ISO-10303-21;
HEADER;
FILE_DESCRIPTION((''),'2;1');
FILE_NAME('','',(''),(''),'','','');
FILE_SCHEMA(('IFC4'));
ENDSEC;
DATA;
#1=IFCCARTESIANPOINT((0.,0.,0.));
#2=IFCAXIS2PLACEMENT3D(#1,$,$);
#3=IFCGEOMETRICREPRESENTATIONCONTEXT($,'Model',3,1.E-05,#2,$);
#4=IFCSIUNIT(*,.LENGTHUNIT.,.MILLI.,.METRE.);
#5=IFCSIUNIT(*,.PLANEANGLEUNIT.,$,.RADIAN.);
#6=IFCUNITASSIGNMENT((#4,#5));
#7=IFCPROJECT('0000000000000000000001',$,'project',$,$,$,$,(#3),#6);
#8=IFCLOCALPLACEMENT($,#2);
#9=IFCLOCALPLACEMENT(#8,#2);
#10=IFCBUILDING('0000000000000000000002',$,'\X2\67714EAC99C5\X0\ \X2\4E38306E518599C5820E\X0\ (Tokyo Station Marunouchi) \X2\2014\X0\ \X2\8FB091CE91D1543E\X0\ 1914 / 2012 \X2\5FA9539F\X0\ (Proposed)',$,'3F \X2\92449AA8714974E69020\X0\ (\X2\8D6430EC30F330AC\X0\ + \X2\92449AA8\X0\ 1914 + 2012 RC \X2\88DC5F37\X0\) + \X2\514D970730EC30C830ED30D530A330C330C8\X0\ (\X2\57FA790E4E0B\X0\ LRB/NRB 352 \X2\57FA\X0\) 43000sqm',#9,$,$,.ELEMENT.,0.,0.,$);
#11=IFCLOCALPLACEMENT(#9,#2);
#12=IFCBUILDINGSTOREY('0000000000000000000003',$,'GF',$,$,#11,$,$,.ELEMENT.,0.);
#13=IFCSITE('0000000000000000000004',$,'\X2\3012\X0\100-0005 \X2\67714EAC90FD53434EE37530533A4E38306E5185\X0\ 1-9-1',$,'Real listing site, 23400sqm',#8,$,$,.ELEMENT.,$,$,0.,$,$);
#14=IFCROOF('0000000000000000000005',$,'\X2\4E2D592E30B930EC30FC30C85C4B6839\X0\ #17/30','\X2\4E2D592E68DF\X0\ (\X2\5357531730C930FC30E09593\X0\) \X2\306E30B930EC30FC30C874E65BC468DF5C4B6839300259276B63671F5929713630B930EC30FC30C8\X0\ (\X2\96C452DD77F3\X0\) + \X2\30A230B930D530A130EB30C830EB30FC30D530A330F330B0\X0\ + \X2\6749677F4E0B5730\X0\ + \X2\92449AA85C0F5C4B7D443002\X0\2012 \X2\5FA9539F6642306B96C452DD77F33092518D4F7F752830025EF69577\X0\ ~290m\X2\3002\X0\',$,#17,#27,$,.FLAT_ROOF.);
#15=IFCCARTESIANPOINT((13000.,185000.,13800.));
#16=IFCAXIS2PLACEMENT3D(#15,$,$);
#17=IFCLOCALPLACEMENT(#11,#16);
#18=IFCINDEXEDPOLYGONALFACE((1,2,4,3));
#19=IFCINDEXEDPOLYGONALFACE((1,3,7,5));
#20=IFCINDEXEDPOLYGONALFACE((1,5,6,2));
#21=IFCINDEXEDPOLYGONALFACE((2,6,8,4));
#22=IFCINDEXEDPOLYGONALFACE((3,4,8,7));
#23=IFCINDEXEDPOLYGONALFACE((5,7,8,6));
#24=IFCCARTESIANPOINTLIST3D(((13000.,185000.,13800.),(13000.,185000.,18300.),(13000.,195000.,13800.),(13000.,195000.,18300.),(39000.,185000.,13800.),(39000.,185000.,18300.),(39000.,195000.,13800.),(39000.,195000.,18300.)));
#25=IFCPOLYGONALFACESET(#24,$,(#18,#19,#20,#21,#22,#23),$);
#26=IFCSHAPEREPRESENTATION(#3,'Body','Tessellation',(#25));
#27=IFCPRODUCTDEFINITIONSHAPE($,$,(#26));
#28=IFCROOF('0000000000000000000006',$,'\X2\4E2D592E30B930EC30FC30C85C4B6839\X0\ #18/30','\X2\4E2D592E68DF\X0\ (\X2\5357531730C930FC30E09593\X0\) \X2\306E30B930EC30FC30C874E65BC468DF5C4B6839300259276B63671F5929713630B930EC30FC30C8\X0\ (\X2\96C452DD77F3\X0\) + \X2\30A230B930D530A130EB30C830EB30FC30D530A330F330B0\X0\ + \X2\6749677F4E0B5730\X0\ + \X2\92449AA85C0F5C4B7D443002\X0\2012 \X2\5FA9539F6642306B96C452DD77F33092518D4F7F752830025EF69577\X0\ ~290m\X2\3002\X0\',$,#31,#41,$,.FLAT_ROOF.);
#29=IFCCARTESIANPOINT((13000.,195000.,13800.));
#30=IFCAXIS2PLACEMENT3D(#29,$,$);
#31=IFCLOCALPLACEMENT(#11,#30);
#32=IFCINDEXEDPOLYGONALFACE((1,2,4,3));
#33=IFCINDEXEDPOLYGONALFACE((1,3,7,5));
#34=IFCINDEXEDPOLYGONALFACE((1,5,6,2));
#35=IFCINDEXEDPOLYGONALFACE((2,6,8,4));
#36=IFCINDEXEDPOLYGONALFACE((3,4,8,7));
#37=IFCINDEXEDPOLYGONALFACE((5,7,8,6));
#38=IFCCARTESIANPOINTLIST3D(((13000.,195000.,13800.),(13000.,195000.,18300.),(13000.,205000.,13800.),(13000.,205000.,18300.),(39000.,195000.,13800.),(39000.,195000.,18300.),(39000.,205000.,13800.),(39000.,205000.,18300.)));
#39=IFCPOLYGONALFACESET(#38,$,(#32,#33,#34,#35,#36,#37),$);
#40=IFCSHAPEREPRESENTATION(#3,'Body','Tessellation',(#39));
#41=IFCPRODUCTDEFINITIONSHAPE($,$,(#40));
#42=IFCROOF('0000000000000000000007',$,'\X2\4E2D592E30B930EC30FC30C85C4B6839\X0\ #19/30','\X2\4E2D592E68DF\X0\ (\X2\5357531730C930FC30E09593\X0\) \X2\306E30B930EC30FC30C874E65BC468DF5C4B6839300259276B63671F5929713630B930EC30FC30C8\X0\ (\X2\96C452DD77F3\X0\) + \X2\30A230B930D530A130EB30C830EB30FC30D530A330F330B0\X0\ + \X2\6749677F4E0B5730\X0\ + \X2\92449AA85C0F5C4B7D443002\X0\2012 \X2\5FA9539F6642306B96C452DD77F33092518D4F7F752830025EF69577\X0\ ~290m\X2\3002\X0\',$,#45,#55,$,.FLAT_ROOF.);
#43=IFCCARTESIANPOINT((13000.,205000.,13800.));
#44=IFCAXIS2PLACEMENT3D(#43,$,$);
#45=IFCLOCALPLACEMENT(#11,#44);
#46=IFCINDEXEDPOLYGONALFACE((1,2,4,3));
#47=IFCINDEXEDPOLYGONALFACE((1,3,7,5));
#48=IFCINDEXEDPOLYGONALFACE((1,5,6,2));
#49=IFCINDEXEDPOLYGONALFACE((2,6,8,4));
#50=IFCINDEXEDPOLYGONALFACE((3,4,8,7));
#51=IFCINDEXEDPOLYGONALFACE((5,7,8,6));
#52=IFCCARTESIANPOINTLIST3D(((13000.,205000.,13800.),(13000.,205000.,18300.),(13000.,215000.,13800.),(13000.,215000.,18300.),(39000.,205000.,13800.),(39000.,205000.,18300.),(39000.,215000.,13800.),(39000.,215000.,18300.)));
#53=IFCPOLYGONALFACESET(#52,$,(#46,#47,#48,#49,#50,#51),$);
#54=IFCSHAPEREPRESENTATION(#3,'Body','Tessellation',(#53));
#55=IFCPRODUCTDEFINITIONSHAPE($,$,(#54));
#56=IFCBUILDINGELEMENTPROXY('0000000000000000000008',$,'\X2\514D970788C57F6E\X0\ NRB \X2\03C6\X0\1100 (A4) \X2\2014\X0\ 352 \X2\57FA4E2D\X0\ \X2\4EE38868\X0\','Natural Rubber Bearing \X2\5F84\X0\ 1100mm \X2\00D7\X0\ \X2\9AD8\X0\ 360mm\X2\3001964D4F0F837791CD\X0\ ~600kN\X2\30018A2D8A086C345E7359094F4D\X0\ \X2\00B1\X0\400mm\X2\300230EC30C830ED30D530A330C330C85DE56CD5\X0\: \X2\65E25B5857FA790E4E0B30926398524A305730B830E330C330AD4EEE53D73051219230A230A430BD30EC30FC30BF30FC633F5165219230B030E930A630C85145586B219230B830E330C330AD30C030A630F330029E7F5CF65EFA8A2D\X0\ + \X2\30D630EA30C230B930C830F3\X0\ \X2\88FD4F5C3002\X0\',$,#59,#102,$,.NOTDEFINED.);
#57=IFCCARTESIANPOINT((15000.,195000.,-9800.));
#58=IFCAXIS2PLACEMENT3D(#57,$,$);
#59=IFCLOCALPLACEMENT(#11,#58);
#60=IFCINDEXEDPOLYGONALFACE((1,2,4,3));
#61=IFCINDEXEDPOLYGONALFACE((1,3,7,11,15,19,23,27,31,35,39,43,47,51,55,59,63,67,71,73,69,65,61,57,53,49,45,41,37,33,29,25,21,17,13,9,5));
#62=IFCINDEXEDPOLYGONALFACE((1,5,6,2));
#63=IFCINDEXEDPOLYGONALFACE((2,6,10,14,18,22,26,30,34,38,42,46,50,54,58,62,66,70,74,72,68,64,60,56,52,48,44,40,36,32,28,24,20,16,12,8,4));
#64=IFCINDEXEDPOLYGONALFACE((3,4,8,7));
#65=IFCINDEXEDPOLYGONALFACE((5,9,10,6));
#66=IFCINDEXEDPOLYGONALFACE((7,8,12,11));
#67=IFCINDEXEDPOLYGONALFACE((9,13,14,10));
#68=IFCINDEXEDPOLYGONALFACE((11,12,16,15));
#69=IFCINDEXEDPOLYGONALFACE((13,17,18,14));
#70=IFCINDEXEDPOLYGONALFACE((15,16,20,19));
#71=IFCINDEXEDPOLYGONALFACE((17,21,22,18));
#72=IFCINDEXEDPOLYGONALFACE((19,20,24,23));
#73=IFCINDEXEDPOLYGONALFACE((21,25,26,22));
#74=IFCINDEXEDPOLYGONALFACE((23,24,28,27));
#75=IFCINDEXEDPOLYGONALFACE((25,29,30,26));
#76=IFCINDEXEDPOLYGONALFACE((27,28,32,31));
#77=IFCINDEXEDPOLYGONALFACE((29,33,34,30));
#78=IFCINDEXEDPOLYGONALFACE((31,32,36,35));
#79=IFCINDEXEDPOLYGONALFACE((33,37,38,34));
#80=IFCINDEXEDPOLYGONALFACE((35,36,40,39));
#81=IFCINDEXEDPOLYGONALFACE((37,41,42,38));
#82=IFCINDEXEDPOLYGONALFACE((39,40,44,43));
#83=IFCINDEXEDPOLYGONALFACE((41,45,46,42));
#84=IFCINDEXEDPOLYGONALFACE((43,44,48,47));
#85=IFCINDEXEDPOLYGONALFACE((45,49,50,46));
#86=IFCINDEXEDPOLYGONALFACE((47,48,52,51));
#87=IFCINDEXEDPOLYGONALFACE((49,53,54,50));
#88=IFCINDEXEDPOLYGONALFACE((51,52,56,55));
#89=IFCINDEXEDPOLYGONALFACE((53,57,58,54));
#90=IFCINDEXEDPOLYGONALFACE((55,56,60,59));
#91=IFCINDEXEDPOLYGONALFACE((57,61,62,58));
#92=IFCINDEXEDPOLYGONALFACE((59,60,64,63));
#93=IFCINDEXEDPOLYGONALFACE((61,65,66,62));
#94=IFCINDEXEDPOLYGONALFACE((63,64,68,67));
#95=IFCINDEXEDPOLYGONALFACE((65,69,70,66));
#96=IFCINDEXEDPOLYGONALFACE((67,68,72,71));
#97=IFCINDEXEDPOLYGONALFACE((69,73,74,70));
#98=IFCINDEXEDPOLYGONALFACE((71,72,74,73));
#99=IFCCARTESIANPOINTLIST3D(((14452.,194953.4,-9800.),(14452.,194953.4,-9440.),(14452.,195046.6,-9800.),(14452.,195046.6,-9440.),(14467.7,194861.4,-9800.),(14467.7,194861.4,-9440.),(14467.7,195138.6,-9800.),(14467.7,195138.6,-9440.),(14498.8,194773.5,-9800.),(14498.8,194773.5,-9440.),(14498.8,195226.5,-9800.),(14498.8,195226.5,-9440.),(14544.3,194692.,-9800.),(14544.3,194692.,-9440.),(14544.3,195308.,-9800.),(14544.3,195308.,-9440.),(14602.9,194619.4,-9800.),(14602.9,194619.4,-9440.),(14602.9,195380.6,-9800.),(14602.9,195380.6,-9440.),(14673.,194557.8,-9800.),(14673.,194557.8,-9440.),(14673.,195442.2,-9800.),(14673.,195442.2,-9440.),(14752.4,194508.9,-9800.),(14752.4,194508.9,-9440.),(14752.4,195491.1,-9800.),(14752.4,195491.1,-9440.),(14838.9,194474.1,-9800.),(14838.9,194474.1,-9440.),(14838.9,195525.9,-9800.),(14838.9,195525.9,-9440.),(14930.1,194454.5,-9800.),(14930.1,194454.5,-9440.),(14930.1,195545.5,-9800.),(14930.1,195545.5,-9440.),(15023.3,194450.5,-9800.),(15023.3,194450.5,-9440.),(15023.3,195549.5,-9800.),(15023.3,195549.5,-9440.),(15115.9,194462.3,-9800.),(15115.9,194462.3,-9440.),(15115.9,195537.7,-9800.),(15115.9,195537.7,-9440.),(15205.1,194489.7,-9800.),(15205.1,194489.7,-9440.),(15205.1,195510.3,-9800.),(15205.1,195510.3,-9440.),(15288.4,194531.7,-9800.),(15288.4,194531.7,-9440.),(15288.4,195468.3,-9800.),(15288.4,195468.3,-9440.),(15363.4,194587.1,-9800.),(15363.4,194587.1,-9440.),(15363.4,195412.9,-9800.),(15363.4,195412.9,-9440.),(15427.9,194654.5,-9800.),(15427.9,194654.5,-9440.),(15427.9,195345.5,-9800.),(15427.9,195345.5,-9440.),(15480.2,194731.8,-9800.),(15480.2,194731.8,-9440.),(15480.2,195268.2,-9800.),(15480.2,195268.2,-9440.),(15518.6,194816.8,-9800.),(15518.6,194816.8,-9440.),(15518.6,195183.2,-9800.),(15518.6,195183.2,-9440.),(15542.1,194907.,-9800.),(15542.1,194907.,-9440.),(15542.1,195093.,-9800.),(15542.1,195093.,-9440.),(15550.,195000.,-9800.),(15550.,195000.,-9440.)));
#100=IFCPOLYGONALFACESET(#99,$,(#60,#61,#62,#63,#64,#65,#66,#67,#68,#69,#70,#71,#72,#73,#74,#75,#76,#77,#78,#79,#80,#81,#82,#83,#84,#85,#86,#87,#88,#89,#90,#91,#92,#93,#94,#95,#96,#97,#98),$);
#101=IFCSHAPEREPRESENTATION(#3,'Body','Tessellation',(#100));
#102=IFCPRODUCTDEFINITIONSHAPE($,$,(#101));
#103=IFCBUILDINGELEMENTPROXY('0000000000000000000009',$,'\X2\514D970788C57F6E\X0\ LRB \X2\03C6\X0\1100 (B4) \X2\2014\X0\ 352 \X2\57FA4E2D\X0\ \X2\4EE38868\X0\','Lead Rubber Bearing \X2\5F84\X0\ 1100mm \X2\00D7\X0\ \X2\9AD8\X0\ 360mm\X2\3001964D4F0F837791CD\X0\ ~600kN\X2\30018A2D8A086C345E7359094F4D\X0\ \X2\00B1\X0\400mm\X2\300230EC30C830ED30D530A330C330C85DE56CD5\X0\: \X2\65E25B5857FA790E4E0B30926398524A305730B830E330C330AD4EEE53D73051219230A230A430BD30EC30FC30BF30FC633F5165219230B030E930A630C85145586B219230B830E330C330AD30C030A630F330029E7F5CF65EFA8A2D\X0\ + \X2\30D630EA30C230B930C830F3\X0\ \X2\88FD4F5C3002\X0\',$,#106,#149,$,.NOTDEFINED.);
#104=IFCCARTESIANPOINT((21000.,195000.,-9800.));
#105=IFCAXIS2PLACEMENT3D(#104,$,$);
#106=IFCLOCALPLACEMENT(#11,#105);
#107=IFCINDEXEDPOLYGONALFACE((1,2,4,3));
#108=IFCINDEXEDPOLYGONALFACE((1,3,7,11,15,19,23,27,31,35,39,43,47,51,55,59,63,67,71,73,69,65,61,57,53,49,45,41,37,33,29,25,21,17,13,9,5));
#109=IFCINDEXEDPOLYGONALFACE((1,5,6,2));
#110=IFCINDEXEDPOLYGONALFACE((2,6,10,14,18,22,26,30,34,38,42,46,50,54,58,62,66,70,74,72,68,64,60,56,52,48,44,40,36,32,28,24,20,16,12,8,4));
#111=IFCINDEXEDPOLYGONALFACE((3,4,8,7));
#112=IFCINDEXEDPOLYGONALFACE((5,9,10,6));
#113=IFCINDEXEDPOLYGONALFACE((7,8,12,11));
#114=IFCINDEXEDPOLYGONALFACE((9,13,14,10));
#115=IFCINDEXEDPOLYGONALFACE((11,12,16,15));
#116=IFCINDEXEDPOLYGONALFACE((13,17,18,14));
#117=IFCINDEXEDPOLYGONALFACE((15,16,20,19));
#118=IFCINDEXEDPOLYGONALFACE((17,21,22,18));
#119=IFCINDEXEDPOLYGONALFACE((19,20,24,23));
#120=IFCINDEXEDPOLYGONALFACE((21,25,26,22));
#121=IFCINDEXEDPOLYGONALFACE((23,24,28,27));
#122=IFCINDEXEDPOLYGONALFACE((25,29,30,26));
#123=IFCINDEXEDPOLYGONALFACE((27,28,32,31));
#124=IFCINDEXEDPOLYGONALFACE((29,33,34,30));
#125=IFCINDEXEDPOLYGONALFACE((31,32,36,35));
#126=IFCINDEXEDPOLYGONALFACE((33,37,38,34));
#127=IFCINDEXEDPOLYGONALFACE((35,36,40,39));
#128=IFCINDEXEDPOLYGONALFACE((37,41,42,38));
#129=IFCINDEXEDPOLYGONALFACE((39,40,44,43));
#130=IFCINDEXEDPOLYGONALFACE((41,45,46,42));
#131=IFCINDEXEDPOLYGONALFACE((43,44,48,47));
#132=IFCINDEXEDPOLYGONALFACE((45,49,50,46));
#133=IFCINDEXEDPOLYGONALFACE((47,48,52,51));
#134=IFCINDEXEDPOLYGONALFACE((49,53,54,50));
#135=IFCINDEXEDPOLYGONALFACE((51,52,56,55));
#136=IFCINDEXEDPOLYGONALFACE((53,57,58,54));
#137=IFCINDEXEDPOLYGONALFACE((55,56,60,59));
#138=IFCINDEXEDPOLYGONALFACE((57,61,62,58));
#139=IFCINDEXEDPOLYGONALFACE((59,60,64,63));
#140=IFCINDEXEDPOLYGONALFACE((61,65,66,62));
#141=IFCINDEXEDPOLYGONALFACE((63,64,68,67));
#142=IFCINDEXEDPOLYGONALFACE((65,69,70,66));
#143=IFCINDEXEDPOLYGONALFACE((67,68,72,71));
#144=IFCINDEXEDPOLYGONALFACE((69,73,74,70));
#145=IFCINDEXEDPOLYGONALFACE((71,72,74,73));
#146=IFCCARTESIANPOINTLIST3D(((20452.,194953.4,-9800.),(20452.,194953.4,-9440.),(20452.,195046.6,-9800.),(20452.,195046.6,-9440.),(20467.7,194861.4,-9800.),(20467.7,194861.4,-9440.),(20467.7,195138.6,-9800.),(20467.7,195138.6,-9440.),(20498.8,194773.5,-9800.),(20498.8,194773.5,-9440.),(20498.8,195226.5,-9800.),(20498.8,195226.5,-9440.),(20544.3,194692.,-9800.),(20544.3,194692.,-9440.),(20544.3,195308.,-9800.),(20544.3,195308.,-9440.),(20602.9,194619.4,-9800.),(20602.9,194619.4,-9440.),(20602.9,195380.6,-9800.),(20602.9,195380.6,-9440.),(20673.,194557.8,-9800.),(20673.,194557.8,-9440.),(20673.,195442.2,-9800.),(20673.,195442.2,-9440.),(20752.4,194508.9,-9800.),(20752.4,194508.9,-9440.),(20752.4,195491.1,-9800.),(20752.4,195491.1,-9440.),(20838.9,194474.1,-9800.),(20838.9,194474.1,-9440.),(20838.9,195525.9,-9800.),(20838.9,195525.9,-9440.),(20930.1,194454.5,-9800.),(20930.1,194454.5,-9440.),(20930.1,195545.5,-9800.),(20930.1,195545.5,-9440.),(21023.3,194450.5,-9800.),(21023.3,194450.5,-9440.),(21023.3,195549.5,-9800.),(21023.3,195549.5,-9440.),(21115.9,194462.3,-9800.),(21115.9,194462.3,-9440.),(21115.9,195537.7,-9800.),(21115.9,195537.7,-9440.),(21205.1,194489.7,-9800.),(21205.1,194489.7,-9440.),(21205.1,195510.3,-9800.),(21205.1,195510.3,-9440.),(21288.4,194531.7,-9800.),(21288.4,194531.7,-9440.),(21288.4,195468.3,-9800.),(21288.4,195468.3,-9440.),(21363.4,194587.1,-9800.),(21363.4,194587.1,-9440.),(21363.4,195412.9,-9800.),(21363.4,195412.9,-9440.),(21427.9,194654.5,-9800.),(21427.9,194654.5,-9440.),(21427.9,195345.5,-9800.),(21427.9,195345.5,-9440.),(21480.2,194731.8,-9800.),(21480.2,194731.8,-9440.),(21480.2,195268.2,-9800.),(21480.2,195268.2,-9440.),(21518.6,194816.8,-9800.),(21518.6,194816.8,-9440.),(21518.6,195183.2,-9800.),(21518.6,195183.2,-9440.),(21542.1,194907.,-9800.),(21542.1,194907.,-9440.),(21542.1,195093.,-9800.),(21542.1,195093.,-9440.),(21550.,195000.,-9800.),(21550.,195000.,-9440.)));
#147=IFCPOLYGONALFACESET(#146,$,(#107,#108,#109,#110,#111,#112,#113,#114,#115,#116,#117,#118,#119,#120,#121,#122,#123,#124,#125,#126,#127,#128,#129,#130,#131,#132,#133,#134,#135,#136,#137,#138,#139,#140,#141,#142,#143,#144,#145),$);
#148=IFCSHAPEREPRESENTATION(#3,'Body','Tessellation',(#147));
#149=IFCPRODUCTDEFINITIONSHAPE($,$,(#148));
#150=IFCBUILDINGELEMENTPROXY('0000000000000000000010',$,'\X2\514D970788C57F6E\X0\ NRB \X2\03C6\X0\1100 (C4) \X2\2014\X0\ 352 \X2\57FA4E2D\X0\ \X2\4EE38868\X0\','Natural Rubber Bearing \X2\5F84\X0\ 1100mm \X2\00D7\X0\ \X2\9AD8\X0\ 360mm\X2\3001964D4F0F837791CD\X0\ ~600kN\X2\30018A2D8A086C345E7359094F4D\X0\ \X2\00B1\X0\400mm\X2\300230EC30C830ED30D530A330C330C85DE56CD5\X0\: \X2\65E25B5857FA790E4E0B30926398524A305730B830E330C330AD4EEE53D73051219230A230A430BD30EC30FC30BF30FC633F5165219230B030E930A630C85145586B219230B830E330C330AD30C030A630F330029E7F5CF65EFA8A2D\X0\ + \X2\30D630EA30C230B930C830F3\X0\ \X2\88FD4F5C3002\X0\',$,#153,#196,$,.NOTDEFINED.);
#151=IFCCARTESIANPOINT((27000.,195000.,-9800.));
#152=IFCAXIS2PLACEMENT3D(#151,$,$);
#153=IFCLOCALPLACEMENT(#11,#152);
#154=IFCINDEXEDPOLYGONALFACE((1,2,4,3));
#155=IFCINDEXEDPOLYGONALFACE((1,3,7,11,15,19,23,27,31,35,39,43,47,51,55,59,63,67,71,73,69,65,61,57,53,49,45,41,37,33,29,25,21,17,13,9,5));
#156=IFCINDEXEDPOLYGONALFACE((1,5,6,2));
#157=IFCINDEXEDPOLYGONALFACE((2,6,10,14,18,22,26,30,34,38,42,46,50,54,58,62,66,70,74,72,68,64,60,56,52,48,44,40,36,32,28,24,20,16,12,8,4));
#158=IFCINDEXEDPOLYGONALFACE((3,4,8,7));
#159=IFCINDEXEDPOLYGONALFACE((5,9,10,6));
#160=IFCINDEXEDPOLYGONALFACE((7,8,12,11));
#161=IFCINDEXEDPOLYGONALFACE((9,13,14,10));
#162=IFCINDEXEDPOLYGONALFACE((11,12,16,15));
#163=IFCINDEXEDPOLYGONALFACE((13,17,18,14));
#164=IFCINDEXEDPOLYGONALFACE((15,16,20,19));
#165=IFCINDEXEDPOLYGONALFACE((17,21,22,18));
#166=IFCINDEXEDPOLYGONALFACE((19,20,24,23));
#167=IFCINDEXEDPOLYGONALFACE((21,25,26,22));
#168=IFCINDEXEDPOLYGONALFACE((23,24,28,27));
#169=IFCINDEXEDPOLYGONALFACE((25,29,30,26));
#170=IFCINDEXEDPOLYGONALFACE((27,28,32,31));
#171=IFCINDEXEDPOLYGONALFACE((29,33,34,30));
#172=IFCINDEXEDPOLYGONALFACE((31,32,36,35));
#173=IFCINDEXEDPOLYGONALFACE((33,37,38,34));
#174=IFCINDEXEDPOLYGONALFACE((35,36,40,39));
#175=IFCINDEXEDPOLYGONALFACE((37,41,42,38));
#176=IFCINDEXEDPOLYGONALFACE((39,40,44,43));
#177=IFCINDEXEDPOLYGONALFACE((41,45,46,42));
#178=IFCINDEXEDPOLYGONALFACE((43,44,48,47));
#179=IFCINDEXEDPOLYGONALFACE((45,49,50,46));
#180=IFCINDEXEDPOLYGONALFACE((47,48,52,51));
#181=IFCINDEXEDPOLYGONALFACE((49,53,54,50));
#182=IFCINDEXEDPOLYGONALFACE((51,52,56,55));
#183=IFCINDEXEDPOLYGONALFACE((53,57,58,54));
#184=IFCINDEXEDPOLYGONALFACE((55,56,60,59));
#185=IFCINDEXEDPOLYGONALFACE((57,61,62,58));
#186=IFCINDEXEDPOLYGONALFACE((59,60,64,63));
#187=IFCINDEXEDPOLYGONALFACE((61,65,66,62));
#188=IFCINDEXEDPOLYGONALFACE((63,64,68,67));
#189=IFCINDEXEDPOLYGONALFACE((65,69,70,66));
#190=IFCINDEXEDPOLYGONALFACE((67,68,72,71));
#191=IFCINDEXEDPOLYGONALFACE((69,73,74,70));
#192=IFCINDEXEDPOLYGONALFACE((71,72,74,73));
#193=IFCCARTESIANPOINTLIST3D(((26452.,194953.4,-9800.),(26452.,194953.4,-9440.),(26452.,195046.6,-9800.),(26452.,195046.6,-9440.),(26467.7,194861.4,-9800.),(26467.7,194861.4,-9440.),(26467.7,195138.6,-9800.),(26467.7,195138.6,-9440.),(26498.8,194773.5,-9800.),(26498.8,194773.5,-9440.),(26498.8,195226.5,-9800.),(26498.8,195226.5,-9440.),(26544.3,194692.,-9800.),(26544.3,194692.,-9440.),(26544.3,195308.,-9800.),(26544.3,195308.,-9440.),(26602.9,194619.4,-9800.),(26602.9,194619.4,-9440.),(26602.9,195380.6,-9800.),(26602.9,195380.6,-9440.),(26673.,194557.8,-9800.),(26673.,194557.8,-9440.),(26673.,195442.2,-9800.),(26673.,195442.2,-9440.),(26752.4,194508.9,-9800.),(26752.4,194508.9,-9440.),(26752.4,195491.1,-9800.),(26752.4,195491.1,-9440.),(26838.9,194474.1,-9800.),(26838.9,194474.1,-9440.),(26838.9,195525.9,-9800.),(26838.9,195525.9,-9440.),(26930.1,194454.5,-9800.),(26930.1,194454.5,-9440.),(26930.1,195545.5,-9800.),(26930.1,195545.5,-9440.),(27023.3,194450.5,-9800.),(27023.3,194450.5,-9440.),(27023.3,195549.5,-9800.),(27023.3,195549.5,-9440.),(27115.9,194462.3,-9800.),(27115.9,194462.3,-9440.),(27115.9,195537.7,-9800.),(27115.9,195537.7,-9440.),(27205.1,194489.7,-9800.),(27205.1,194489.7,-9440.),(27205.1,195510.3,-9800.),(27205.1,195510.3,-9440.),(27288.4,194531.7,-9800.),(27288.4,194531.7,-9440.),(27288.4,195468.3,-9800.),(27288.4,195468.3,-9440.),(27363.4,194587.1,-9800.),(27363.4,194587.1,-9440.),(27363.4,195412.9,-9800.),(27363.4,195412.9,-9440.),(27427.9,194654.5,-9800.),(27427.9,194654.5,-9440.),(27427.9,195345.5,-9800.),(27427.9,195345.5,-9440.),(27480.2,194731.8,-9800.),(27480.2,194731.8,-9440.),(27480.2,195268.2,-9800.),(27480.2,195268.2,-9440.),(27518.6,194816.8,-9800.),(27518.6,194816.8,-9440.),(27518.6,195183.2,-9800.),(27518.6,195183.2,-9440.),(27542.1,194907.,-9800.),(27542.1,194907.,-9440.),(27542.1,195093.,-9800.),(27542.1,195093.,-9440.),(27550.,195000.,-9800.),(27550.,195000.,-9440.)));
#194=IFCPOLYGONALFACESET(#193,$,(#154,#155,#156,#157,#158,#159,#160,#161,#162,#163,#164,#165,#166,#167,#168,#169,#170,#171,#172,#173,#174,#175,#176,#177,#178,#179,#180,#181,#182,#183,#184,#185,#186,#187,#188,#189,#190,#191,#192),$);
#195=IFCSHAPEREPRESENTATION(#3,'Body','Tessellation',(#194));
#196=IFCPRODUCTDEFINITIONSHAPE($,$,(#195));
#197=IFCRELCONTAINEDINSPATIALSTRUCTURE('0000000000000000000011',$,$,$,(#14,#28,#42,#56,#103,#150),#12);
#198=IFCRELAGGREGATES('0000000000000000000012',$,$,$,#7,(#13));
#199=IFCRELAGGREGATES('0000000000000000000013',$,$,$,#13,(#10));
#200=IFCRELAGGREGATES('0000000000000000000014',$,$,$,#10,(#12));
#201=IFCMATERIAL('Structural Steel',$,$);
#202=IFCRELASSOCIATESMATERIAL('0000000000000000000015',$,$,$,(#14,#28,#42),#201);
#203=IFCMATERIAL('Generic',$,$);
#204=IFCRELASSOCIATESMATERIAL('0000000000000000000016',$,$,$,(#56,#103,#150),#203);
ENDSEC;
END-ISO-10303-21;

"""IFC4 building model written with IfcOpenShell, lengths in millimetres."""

from ifc_helpers import new_model, si_unit, frame, frame_2d, origin, origin_2d, place, context, project, spatial, rectangle, circle, extrude, material, element, save


model = new_model("IFC4")

# Units and contexts
model_context = context("Model", 3, precision=1e-05, world=origin())
ifc_project = project(units=[si_unit("LENGTHUNIT", "METRE", prefix="MILLI"), si_unit("PLANEANGLEUNIT", "RADIAN")], contexts=[model_context])

# Site, building, storey
site_placement = place(None, origin())
site = spatial("IfcSite", under=ifc_project, at=site_placement, Name="〒100-0005 東京都千代田区丸の内 1-9-1", ObjectType="Real listing site, 23400sqm", CompositionType="ELEMENT", RefElevation=0.0)
building_placement = place(site_placement, origin())
building = spatial("IfcBuilding", under=site, at=building_placement, Name="東京駅 丸の内駅舎 (Tokyo Station Marunouchi) — 辰野金吾 1914 / 2012 復原 (Proposed)", ObjectType="3F 鉄骨煉瓦造 (赤レンガ + 鉄骨 1914 + 2012 RC 補強) + 免震レトロフィット (基礎下 LRB/NRB 352 基) 43000sqm", CompositionType="ELEMENT", ElevationOfRefHeight=0.0, ElevationOfTerrain=0.0)
storey_placement = place(building_placement, origin())
storey = spatial("IfcBuildingStorey", under=building, at=storey_placement, Name="GF", CompositionType="ELEMENT", Elevation=0.0)

# Shared definitions
ifc_material_1 = material(Name="Structural Steel")

# Shared definitions
ifc_material_2 = material(Name="Generic")

# Roofs
roof_1_placement = place(storey_placement, frame((13000.0, 185000.0, 13800.0)))
element("IfcRoof", 1, at=roof_1_placement, inside=storey, material=ifc_material_1, Name="中央スレート屋根 #17/30", Description="中央棟 (南北ドーム間) のスレート瓦寄棟屋根。大正期天然スレート (雄勝石) + アスファルトルーフィング + 杉板下地 + 鉄骨小屋組。2012 復原時に雄勝石を再使用。延長 ~290m。", PredefinedType="FLAT_ROOF", context=model_context, shape_type="SweptSolid", body=[
    extrude(rectangle(XDim=26000.0, YDim=10000.0, at=frame_2d((13000.0, 5000.0))), frame((13000.0, 185000.0, 13800.0)), (0.0, 0.0, 1.0), 4500.0),
])
roof_2_placement = place(storey_placement, frame((13000.0, 195000.0, 13800.0)))
element("IfcRoof", 2, at=roof_2_placement, inside=storey, material=ifc_material_1, Name="中央スレート屋根 #18/30", Description="中央棟 (南北ドーム間) のスレート瓦寄棟屋根。大正期天然スレート (雄勝石) + アスファルトルーフィング + 杉板下地 + 鉄骨小屋組。2012 復原時に雄勝石を再使用。延長 ~290m。", PredefinedType="FLAT_ROOF", context=model_context, shape_type="SweptSolid", body=[
    extrude(rectangle(XDim=26000.0, YDim=10000.0, at=frame_2d((13000.0, 5000.0))), frame((13000.0, 195000.0, 13800.0)), (0.0, 0.0, 1.0), 4500.0),
])
roof_3_placement = place(storey_placement, frame((13000.0, 205000.0, 13800.0)))
element("IfcRoof", 3, at=roof_3_placement, inside=storey, material=ifc_material_1, Name="中央スレート屋根 #19/30", Description="中央棟 (南北ドーム間) のスレート瓦寄棟屋根。大正期天然スレート (雄勝石) + アスファルトルーフィング + 杉板下地 + 鉄骨小屋組。2012 復原時に雄勝石を再使用。延長 ~290m。", PredefinedType="FLAT_ROOF", context=model_context, shape_type="SweptSolid", body=[
    extrude(rectangle(XDim=26000.0, YDim=10000.0, at=frame_2d((13000.0, 5000.0))), frame((13000.0, 205000.0, 13800.0)), (0.0, 0.0, 1.0), 4500.0),
])

# Building element proxies
proxy_1_placement = place(storey_placement, frame((15000.0, 195000.0, -9800.0)))
element("IfcBuildingElementProxy", 4, at=proxy_1_placement, inside=storey, material=ifc_material_2, Name="免震装置 NRB φ1100 (A4) — 352 基中 代表", Description="Natural Rubber Bearing 径 1100mm × 高 360mm、降伏荷重 ~600kN、設計水平変位 ±400mm。レトロフィット工法: 既存基礎下を掘削しジャッキ仮受け→アイソレーター挿入→グラウト充填→ジャッキダウン。鹿島建設 + ブリヂストン 製作。", PredefinedType="NOTDEFINED", context=model_context, shape_type="SweptSolid", body=[
    extrude(circle(Radius=550.0, at=origin_2d()), frame((15000.0, 195000.0, -9800.0)), (0.0, 0.0, 1.0), 360.0),
])
proxy_2_placement = place(storey_placement, frame((21000.0, 195000.0, -9800.0)))
element("IfcBuildingElementProxy", 5, at=proxy_2_placement, inside=storey, material=ifc_material_2, Name="免震装置 LRB φ1100 (B4) — 352 基中 代表", Description="Lead Rubber Bearing 径 1100mm × 高 360mm、降伏荷重 ~600kN、設計水平変位 ±400mm。レトロフィット工法: 既存基礎下を掘削しジャッキ仮受け→アイソレーター挿入→グラウト充填→ジャッキダウン。鹿島建設 + ブリヂストン 製作。", PredefinedType="NOTDEFINED", context=model_context, shape_type="SweptSolid", body=[
    extrude(circle(Radius=550.0, at=origin_2d()), frame((21000.0, 195000.0, -9800.0)), (0.0, 0.0, 1.0), 360.0),
])
proxy_3_placement = place(storey_placement, frame((27000.0, 195000.0, -9800.0)))
element("IfcBuildingElementProxy", 6, at=proxy_3_placement, inside=storey, material=ifc_material_2, Name="免震装置 NRB φ1100 (C4) — 352 基中 代表", Description="Natural Rubber Bearing 径 1100mm × 高 360mm、降伏荷重 ~600kN、設計水平変位 ±400mm。レトロフィット工法: 既存基礎下を掘削しジャッキ仮受け→アイソレーター挿入→グラウト充填→ジャッキダウン。鹿島建設 + ブリヂストン 製作。", PredefinedType="NOTDEFINED", context=model_context, shape_type="SweptSolid", body=[
    extrude(circle(Radius=550.0, at=origin_2d()), frame((27000.0, 195000.0, -9800.0)), (0.0, 0.0, 1.0), 360.0),
])

save(model, "model.ifc")
